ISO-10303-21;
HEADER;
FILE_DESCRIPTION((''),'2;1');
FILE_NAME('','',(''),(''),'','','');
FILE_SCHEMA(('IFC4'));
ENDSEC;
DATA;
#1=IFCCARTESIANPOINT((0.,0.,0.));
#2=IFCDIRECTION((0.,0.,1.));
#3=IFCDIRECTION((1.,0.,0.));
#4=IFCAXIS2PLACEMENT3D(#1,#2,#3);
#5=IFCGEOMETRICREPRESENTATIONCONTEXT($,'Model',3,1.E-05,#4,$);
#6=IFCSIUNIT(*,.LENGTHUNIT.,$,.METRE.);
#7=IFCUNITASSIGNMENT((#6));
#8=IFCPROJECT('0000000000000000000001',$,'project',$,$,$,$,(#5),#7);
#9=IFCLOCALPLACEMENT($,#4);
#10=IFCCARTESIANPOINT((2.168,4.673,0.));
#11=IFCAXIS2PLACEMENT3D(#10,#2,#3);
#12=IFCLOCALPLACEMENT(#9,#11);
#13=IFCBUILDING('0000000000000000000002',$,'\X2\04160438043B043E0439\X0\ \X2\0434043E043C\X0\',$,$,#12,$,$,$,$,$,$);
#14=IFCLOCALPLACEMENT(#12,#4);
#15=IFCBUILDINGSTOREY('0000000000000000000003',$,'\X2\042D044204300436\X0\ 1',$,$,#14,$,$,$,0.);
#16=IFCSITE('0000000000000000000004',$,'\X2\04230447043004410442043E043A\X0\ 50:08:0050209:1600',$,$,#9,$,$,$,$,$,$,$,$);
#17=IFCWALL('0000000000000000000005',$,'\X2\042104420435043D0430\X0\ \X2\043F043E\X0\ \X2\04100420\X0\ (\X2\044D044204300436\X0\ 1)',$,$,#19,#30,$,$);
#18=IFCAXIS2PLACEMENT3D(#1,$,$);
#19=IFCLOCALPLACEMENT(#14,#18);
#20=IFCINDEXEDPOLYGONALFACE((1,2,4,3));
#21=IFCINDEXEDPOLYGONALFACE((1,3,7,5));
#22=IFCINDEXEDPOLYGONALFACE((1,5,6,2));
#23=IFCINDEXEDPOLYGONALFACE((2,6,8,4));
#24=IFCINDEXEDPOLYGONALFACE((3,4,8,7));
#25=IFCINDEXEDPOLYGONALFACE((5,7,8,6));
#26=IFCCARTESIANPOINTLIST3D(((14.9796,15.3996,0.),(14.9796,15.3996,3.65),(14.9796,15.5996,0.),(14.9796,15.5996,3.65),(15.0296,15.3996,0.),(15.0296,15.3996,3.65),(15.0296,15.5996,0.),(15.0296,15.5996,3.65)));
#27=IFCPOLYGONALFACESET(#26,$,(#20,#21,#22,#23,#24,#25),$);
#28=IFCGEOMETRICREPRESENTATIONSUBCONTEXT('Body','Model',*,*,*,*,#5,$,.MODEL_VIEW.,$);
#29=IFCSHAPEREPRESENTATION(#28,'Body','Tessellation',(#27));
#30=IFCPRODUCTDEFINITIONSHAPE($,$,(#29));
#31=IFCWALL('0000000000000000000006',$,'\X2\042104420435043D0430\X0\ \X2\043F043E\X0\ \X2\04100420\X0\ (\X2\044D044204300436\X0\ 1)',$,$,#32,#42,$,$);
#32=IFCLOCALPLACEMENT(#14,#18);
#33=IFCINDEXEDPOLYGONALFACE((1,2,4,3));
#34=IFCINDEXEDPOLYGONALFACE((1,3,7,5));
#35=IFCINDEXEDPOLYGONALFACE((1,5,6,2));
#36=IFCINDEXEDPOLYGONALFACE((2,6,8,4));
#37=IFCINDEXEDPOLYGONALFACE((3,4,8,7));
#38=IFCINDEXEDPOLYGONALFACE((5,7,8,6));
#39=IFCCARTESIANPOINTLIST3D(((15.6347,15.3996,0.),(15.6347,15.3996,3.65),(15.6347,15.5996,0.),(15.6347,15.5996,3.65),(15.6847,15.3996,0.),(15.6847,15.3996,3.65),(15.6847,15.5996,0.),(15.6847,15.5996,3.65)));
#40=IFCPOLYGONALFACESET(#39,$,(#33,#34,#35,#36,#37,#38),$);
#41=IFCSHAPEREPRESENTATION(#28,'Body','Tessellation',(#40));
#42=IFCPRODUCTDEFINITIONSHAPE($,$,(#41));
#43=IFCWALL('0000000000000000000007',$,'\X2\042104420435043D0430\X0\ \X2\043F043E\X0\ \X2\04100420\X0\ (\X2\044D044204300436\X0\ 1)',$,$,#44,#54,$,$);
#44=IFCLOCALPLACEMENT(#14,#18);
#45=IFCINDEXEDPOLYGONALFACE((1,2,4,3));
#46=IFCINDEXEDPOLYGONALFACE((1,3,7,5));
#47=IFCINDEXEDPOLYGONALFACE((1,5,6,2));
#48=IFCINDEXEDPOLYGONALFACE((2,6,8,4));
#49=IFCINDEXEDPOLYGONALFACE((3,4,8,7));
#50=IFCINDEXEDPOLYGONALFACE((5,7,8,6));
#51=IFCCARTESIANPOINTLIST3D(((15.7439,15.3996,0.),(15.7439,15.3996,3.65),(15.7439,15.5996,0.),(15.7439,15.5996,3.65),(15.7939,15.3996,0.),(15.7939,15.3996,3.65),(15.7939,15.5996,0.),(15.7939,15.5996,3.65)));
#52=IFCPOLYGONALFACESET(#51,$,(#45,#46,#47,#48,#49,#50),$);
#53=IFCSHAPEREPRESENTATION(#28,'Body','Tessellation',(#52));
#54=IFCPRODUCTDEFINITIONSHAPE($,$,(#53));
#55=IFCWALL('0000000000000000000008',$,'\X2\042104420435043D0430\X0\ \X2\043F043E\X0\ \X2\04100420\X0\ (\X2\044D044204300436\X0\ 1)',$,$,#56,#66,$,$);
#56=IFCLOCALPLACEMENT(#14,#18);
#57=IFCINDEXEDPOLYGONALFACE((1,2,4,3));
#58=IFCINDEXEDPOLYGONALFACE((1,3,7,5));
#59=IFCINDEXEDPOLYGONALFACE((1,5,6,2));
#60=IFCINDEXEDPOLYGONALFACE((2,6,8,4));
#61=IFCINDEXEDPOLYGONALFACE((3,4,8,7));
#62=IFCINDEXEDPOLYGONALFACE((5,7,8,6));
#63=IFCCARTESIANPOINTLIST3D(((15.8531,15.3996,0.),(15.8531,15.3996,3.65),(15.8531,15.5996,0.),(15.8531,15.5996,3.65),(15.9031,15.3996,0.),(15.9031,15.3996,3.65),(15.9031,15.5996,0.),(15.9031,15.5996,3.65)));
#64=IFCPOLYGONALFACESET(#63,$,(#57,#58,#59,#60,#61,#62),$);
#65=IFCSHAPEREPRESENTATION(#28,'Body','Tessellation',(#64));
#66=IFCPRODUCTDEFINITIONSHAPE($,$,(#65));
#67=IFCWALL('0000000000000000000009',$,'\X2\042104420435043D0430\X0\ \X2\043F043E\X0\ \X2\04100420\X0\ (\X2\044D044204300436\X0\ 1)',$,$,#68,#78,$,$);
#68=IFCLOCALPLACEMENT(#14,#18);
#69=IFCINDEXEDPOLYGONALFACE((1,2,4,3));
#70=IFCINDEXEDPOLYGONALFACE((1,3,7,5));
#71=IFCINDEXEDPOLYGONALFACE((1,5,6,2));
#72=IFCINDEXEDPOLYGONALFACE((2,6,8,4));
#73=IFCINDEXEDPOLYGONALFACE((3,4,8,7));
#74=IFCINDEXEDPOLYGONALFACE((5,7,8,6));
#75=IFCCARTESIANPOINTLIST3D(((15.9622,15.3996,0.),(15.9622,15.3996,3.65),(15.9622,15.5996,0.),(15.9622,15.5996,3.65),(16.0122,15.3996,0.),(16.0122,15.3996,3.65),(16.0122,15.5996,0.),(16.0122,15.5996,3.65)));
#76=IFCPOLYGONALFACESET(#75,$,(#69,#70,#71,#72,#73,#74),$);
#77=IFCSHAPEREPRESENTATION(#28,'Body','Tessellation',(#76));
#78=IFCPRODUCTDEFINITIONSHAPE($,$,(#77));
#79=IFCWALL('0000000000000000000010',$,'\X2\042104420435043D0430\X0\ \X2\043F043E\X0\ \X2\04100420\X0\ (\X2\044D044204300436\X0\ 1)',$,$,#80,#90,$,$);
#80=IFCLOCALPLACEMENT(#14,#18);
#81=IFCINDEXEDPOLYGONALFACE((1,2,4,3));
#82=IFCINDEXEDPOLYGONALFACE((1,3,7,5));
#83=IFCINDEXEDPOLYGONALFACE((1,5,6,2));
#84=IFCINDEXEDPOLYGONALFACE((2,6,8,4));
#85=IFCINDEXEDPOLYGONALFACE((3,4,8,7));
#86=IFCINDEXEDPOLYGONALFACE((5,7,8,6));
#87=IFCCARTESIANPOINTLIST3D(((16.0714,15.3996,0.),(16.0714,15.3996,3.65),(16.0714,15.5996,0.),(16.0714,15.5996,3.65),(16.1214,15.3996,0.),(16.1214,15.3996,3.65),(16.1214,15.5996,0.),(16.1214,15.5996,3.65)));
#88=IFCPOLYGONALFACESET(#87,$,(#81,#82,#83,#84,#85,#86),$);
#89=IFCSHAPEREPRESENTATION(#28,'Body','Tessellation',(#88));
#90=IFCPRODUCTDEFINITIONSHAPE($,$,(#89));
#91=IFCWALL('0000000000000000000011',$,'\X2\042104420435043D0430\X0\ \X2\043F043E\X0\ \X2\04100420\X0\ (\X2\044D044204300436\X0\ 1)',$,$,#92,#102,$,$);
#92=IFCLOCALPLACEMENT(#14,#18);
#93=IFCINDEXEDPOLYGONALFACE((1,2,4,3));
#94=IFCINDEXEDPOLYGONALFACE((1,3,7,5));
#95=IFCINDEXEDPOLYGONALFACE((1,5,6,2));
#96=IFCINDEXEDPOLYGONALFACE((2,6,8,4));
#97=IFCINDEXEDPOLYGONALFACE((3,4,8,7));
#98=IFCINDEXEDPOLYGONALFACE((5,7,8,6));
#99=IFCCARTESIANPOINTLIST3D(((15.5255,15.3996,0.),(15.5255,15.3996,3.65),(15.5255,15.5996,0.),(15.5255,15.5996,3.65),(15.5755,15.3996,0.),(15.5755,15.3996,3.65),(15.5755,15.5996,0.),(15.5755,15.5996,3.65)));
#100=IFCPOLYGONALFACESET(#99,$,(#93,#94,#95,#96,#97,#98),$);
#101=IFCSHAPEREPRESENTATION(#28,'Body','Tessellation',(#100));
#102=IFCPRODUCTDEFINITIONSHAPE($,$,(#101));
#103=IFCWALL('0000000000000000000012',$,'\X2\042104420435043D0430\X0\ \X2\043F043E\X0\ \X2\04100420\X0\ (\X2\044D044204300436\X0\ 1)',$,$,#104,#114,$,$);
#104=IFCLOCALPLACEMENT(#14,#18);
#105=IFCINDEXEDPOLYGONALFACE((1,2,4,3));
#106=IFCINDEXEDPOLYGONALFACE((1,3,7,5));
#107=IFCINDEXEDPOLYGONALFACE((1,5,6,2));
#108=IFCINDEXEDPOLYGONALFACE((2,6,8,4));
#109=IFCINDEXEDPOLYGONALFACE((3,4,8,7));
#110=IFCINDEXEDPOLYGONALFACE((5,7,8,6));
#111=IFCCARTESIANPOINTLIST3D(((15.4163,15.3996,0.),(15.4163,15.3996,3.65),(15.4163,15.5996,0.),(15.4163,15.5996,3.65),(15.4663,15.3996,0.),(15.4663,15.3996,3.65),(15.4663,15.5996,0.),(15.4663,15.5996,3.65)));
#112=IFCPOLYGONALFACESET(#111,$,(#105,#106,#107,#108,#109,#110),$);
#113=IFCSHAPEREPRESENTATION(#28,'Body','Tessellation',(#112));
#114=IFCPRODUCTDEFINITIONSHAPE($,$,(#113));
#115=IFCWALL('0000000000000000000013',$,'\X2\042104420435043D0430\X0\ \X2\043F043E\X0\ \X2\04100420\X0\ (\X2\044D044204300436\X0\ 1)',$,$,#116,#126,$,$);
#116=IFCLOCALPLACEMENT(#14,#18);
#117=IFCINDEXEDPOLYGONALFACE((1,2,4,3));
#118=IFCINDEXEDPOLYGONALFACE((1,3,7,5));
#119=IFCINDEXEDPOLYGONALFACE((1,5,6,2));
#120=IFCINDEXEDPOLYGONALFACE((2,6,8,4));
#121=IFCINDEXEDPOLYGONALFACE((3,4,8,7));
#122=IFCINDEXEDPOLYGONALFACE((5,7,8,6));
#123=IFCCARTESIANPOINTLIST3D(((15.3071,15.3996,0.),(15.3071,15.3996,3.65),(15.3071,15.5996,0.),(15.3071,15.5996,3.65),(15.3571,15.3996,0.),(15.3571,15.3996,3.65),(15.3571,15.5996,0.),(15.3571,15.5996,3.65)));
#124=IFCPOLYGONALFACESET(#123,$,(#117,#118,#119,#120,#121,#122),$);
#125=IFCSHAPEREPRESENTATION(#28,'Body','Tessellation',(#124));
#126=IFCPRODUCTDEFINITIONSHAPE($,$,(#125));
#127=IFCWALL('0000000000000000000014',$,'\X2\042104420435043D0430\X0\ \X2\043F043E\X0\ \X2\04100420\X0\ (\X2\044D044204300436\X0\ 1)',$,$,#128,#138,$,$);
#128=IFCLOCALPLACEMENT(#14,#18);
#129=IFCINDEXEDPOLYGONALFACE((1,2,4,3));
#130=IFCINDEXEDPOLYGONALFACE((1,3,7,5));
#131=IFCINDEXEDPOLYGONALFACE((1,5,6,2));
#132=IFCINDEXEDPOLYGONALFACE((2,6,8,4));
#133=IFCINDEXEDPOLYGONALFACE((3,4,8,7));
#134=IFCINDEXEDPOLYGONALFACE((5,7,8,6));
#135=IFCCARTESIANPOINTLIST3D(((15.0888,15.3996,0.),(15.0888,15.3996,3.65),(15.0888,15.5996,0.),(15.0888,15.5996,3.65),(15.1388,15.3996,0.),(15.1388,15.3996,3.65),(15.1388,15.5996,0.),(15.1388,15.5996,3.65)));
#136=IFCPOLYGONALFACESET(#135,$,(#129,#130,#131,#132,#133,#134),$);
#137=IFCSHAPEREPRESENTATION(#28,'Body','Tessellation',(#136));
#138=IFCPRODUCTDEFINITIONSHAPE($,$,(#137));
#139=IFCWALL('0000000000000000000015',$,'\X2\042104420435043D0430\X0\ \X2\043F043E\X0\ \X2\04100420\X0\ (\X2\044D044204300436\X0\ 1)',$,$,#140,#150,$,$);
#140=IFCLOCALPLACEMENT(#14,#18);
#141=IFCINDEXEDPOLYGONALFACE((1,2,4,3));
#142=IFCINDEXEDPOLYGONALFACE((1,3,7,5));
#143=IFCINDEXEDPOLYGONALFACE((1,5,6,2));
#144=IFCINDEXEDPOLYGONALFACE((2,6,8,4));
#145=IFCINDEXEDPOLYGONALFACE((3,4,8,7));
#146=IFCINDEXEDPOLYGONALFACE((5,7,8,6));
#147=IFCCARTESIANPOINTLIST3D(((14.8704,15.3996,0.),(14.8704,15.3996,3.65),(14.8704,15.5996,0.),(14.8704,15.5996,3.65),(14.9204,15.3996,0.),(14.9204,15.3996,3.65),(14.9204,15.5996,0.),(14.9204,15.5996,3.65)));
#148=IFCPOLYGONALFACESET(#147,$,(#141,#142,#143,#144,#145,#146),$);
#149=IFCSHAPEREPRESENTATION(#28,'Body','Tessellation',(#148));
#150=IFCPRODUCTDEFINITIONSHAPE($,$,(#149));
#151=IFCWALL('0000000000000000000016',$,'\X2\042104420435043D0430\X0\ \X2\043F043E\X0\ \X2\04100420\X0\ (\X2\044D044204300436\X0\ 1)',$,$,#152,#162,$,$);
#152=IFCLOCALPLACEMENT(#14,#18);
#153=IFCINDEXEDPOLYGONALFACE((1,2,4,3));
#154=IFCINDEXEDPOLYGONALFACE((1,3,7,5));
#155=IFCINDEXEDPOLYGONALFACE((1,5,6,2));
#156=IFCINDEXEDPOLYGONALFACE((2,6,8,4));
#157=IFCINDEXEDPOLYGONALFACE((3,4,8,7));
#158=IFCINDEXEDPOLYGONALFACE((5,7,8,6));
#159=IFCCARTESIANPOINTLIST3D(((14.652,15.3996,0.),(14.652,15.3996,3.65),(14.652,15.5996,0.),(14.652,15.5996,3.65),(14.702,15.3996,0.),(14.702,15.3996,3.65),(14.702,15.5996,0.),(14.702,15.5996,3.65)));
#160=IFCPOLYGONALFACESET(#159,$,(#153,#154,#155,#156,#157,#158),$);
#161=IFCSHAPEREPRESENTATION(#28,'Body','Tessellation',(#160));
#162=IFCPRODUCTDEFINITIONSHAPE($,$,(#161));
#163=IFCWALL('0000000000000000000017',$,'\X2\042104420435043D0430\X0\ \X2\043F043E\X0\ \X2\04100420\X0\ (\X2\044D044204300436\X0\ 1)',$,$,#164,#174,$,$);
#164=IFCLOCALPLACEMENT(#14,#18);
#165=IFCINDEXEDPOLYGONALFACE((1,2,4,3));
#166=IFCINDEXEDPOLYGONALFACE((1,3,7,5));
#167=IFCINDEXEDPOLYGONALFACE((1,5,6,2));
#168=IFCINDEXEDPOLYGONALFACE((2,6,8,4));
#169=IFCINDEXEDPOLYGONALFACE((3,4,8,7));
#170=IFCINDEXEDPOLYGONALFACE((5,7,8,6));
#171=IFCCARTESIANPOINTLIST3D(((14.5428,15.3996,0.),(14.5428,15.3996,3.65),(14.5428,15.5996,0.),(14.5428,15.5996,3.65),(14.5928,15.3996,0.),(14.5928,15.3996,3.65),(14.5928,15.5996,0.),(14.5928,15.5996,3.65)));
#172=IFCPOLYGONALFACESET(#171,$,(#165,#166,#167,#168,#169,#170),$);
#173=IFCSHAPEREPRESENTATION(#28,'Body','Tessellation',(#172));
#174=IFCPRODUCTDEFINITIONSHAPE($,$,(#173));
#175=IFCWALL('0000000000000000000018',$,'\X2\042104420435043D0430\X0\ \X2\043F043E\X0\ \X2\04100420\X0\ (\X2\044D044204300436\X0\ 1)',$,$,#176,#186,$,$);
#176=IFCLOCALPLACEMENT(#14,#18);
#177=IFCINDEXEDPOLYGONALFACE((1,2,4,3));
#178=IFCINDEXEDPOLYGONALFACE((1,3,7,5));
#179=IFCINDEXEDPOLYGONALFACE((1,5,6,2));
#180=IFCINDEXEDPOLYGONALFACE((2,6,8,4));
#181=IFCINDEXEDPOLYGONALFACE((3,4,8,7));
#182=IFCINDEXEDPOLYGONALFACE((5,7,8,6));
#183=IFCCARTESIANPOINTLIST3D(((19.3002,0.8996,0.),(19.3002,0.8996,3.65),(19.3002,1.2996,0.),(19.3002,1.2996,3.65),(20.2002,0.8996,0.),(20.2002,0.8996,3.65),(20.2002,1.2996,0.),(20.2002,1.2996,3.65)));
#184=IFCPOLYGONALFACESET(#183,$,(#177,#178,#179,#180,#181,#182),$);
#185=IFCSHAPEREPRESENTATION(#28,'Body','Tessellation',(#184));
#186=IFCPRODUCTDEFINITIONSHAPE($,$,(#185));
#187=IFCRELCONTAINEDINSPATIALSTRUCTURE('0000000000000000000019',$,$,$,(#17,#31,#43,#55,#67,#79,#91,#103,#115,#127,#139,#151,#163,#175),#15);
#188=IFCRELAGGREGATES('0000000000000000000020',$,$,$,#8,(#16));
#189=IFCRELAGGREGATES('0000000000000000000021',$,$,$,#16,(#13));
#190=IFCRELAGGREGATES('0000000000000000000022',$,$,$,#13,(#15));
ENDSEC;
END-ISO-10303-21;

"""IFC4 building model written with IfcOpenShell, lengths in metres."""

from ifc_helpers import new_model, si_unit, frame, origin_with_axes, place, context, subcontext, project, spatial, polyline, outline, extrude, element, save


model = new_model("IFC4")

# Units and contexts
model_context = context("Model", 3, precision=1e-05, world=origin_with_axes())
body_context = subcontext(model_context, "Body", "Model", "MODEL_VIEW")
ifc_project = project(units=[si_unit("LENGTHUNIT", "METRE")], contexts=[model_context])

# Site, building, storey
site_placement = place(None, origin_with_axes())
site = spatial("IfcSite", under=ifc_project, at=site_placement, Name="Участок 50:08:0050209:1600")
building_placement = place(site_placement, frame((2.168, 4.673, 0.0), z_axis=(0.0, 0.0, 1.0), x_axis=(1.0, 0.0, 0.0)))
building = spatial("IfcBuilding", under=site, at=building_placement, Name="Жилой дом")
storey_placement = place(building_placement, origin_with_axes())
storey = spatial("IfcBuildingStorey", under=building, at=storey_placement, Name="Этаж 1", Elevation=0.0)

# Walls
wall_1_placement = place(storey_placement, origin_with_axes())
element("IfcWall", 1, at=wall_1_placement, inside=storey, Name="Стена по АР (этаж 1)", context=body_context, shape_type="SweptSolid", body=[
    extrude(outline(polyline([(15.0296, 15.5996), (15.0296, 15.3996), (14.9796, 15.3996), (14.9796, 15.5996), (15.0296, 15.5996)])), origin_with_axes(), (0.0, 0.0, 1.0), 3.65),
])
wall_2_placement = place(storey_placement, origin_with_axes())
element("IfcWall", 2, at=wall_2_placement, inside=storey, Name="Стена по АР (этаж 1)", context=body_context, shape_type="SweptSolid", body=[
    extrude(outline(polyline([(15.6847, 15.3996), (15.6347, 15.3996), (15.6347, 15.5996), (15.6847, 15.5996), (15.6847, 15.3996)])), origin_with_axes(), (0.0, 0.0, 1.0), 3.65),
])
wall_3_placement = place(storey_placement, origin_with_axes())
element("IfcWall", 3, at=wall_3_placement, inside=storey, Name="Стена по АР (этаж 1)", context=body_context, shape_type="SweptSolid", body=[
    extrude(outline(polyline([(15.7939, 15.3996), (15.7439, 15.3996), (15.7439, 15.5996), (15.7939, 15.5996), (15.7939, 15.3996)])), origin_with_axes(), (0.0, 0.0, 1.0), 3.65),
])
wall_4_placement = place(storey_placement, origin_with_axes())
element("IfcWall", 4, at=wall_4_placement, inside=storey, Name="Стена по АР (этаж 1)", context=body_context, shape_type="SweptSolid", body=[
    extrude(outline(polyline([(15.9031, 15.5996), (15.9031, 15.3996), (15.8531, 15.3996), (15.8531, 15.5996), (15.9031, 15.5996)])), origin_with_axes(), (0.0, 0.0, 1.0), 3.65),
])
wall_5_placement = place(storey_placement, origin_with_axes())
element("IfcWall", 5, at=wall_5_placement, inside=storey, Name="Стена по АР (этаж 1)", context=body_context, shape_type="SweptSolid", body=[
    extrude(outline(polyline([(16.0122, 15.5996), (16.0122, 15.3996), (15.9622, 15.3996), (15.9622, 15.5996), (16.0122, 15.5996)])), origin_with_axes(), (0.0, 0.0, 1.0), 3.65),
])
wall_6_placement = place(storey_placement, origin_with_axes())
element("IfcWall", 6, at=wall_6_placement, inside=storey, Name="Стена по АР (этаж 1)", context=body_context, shape_type="SweptSolid", body=[
    extrude(outline(polyline([(16.1214, 15.5996), (16.1214, 15.3996), (16.0714, 15.3996), (16.0714, 15.5996), (16.1214, 15.5996)])), origin_with_axes(), (0.0, 0.0, 1.0), 3.65),
])
wall_7_placement = place(storey_placement, origin_with_axes())
element("IfcWall", 7, at=wall_7_placement, inside=storey, Name="Стена по АР (этаж 1)", context=body_context, shape_type="SweptSolid", body=[
    extrude(outline(polyline([(15.5755, 15.3996), (15.5255, 15.3996), (15.5255, 15.5996), (15.5755, 15.5996), (15.5755, 15.3996)])), origin_with_axes(), (0.0, 0.0, 1.0), 3.65),
])
wall_8_placement = place(storey_placement, origin_with_axes())
element("IfcWall", 8, at=wall_8_placement, inside=storey, Name="Стена по АР (этаж 1)", context=body_context, shape_type="SweptSolid", body=[
    extrude(outline(polyline([(15.4663, 15.3996), (15.4163, 15.3996), (15.4163, 15.5996), (15.4663, 15.5996), (15.4663, 15.3996)])), origin_with_axes(), (0.0, 0.0, 1.0), 3.65),
])
wall_9_placement = place(storey_placement, origin_with_axes())
element("IfcWall", 9, at=wall_9_placement, inside=storey, Name="Стена по АР (этаж 1)", context=body_context, shape_type="SweptSolid", body=[
    extrude(outline(polyline([(15.3571, 15.5996), (15.3571, 15.3996), (15.3071, 15.3996), (15.3071, 15.5996), (15.3571, 15.5996)])), origin_with_axes(), (0.0, 0.0, 1.0), 3.65),
])
wall_10_placement = place(storey_placement, origin_with_axes())
element("IfcWall", 10, at=wall_10_placement, inside=storey, Name="Стена по АР (этаж 1)", context=body_context, shape_type="SweptSolid", body=[
    extrude(outline(polyline([(15.1388, 15.5996), (15.1388, 15.3996), (15.0888, 15.3996), (15.0888, 15.5996), (15.1388, 15.5996)])), origin_with_axes(), (0.0, 0.0, 1.0), 3.65),
])
wall_11_placement = place(storey_placement, origin_with_axes())
element("IfcWall", 11, at=wall_11_placement, inside=storey, Name="Стена по АР (этаж 1)", context=body_context, shape_type="SweptSolid", body=[
    extrude(outline(polyline([(14.9204, 15.5996), (14.9204, 15.3996), (14.8704, 15.3996), (14.8704, 15.5996), (14.9204, 15.5996)])), origin_with_axes(), (0.0, 0.0, 1.0), 3.65),
])
wall_12_placement = place(storey_placement, origin_with_axes())
element("IfcWall", 12, at=wall_12_placement, inside=storey, Name="Стена по АР (этаж 1)", context=body_context, shape_type="SweptSolid", body=[
    extrude(outline(polyline([(14.702, 15.3996), (14.652, 15.3996), (14.652, 15.5996), (14.702, 15.5996), (14.702, 15.3996)])), origin_with_axes(), (0.0, 0.0, 1.0), 3.65),
])
wall_13_placement = place(storey_placement, origin_with_axes())
element("IfcWall", 13, at=wall_13_placement, inside=storey, Name="Стена по АР (этаж 1)", context=body_context, shape_type="SweptSolid", body=[
    extrude(outline(polyline([(14.5928, 15.3996), (14.5428, 15.3996), (14.5428, 15.5996), (14.5928, 15.5996), (14.5928, 15.3996)])), origin_with_axes(), (0.0, 0.0, 1.0), 3.65),
])
wall_14_placement = place(storey_placement, origin_with_axes())
element("IfcWall", 14, at=wall_14_placement, inside=storey, Name="Стена по АР (этаж 1)", context=body_context, shape_type="SweptSolid", body=[
    extrude(outline(polyline([(20.2002, 1.2996), (20.2002, 0.8996), (19.3002, 0.8996), (19.3002, 1.2996), (20.2002, 1.2996)])), origin_with_axes(), (0.0, 0.0, 1.0), 3.65),
])

save(model, "model.ifc")
